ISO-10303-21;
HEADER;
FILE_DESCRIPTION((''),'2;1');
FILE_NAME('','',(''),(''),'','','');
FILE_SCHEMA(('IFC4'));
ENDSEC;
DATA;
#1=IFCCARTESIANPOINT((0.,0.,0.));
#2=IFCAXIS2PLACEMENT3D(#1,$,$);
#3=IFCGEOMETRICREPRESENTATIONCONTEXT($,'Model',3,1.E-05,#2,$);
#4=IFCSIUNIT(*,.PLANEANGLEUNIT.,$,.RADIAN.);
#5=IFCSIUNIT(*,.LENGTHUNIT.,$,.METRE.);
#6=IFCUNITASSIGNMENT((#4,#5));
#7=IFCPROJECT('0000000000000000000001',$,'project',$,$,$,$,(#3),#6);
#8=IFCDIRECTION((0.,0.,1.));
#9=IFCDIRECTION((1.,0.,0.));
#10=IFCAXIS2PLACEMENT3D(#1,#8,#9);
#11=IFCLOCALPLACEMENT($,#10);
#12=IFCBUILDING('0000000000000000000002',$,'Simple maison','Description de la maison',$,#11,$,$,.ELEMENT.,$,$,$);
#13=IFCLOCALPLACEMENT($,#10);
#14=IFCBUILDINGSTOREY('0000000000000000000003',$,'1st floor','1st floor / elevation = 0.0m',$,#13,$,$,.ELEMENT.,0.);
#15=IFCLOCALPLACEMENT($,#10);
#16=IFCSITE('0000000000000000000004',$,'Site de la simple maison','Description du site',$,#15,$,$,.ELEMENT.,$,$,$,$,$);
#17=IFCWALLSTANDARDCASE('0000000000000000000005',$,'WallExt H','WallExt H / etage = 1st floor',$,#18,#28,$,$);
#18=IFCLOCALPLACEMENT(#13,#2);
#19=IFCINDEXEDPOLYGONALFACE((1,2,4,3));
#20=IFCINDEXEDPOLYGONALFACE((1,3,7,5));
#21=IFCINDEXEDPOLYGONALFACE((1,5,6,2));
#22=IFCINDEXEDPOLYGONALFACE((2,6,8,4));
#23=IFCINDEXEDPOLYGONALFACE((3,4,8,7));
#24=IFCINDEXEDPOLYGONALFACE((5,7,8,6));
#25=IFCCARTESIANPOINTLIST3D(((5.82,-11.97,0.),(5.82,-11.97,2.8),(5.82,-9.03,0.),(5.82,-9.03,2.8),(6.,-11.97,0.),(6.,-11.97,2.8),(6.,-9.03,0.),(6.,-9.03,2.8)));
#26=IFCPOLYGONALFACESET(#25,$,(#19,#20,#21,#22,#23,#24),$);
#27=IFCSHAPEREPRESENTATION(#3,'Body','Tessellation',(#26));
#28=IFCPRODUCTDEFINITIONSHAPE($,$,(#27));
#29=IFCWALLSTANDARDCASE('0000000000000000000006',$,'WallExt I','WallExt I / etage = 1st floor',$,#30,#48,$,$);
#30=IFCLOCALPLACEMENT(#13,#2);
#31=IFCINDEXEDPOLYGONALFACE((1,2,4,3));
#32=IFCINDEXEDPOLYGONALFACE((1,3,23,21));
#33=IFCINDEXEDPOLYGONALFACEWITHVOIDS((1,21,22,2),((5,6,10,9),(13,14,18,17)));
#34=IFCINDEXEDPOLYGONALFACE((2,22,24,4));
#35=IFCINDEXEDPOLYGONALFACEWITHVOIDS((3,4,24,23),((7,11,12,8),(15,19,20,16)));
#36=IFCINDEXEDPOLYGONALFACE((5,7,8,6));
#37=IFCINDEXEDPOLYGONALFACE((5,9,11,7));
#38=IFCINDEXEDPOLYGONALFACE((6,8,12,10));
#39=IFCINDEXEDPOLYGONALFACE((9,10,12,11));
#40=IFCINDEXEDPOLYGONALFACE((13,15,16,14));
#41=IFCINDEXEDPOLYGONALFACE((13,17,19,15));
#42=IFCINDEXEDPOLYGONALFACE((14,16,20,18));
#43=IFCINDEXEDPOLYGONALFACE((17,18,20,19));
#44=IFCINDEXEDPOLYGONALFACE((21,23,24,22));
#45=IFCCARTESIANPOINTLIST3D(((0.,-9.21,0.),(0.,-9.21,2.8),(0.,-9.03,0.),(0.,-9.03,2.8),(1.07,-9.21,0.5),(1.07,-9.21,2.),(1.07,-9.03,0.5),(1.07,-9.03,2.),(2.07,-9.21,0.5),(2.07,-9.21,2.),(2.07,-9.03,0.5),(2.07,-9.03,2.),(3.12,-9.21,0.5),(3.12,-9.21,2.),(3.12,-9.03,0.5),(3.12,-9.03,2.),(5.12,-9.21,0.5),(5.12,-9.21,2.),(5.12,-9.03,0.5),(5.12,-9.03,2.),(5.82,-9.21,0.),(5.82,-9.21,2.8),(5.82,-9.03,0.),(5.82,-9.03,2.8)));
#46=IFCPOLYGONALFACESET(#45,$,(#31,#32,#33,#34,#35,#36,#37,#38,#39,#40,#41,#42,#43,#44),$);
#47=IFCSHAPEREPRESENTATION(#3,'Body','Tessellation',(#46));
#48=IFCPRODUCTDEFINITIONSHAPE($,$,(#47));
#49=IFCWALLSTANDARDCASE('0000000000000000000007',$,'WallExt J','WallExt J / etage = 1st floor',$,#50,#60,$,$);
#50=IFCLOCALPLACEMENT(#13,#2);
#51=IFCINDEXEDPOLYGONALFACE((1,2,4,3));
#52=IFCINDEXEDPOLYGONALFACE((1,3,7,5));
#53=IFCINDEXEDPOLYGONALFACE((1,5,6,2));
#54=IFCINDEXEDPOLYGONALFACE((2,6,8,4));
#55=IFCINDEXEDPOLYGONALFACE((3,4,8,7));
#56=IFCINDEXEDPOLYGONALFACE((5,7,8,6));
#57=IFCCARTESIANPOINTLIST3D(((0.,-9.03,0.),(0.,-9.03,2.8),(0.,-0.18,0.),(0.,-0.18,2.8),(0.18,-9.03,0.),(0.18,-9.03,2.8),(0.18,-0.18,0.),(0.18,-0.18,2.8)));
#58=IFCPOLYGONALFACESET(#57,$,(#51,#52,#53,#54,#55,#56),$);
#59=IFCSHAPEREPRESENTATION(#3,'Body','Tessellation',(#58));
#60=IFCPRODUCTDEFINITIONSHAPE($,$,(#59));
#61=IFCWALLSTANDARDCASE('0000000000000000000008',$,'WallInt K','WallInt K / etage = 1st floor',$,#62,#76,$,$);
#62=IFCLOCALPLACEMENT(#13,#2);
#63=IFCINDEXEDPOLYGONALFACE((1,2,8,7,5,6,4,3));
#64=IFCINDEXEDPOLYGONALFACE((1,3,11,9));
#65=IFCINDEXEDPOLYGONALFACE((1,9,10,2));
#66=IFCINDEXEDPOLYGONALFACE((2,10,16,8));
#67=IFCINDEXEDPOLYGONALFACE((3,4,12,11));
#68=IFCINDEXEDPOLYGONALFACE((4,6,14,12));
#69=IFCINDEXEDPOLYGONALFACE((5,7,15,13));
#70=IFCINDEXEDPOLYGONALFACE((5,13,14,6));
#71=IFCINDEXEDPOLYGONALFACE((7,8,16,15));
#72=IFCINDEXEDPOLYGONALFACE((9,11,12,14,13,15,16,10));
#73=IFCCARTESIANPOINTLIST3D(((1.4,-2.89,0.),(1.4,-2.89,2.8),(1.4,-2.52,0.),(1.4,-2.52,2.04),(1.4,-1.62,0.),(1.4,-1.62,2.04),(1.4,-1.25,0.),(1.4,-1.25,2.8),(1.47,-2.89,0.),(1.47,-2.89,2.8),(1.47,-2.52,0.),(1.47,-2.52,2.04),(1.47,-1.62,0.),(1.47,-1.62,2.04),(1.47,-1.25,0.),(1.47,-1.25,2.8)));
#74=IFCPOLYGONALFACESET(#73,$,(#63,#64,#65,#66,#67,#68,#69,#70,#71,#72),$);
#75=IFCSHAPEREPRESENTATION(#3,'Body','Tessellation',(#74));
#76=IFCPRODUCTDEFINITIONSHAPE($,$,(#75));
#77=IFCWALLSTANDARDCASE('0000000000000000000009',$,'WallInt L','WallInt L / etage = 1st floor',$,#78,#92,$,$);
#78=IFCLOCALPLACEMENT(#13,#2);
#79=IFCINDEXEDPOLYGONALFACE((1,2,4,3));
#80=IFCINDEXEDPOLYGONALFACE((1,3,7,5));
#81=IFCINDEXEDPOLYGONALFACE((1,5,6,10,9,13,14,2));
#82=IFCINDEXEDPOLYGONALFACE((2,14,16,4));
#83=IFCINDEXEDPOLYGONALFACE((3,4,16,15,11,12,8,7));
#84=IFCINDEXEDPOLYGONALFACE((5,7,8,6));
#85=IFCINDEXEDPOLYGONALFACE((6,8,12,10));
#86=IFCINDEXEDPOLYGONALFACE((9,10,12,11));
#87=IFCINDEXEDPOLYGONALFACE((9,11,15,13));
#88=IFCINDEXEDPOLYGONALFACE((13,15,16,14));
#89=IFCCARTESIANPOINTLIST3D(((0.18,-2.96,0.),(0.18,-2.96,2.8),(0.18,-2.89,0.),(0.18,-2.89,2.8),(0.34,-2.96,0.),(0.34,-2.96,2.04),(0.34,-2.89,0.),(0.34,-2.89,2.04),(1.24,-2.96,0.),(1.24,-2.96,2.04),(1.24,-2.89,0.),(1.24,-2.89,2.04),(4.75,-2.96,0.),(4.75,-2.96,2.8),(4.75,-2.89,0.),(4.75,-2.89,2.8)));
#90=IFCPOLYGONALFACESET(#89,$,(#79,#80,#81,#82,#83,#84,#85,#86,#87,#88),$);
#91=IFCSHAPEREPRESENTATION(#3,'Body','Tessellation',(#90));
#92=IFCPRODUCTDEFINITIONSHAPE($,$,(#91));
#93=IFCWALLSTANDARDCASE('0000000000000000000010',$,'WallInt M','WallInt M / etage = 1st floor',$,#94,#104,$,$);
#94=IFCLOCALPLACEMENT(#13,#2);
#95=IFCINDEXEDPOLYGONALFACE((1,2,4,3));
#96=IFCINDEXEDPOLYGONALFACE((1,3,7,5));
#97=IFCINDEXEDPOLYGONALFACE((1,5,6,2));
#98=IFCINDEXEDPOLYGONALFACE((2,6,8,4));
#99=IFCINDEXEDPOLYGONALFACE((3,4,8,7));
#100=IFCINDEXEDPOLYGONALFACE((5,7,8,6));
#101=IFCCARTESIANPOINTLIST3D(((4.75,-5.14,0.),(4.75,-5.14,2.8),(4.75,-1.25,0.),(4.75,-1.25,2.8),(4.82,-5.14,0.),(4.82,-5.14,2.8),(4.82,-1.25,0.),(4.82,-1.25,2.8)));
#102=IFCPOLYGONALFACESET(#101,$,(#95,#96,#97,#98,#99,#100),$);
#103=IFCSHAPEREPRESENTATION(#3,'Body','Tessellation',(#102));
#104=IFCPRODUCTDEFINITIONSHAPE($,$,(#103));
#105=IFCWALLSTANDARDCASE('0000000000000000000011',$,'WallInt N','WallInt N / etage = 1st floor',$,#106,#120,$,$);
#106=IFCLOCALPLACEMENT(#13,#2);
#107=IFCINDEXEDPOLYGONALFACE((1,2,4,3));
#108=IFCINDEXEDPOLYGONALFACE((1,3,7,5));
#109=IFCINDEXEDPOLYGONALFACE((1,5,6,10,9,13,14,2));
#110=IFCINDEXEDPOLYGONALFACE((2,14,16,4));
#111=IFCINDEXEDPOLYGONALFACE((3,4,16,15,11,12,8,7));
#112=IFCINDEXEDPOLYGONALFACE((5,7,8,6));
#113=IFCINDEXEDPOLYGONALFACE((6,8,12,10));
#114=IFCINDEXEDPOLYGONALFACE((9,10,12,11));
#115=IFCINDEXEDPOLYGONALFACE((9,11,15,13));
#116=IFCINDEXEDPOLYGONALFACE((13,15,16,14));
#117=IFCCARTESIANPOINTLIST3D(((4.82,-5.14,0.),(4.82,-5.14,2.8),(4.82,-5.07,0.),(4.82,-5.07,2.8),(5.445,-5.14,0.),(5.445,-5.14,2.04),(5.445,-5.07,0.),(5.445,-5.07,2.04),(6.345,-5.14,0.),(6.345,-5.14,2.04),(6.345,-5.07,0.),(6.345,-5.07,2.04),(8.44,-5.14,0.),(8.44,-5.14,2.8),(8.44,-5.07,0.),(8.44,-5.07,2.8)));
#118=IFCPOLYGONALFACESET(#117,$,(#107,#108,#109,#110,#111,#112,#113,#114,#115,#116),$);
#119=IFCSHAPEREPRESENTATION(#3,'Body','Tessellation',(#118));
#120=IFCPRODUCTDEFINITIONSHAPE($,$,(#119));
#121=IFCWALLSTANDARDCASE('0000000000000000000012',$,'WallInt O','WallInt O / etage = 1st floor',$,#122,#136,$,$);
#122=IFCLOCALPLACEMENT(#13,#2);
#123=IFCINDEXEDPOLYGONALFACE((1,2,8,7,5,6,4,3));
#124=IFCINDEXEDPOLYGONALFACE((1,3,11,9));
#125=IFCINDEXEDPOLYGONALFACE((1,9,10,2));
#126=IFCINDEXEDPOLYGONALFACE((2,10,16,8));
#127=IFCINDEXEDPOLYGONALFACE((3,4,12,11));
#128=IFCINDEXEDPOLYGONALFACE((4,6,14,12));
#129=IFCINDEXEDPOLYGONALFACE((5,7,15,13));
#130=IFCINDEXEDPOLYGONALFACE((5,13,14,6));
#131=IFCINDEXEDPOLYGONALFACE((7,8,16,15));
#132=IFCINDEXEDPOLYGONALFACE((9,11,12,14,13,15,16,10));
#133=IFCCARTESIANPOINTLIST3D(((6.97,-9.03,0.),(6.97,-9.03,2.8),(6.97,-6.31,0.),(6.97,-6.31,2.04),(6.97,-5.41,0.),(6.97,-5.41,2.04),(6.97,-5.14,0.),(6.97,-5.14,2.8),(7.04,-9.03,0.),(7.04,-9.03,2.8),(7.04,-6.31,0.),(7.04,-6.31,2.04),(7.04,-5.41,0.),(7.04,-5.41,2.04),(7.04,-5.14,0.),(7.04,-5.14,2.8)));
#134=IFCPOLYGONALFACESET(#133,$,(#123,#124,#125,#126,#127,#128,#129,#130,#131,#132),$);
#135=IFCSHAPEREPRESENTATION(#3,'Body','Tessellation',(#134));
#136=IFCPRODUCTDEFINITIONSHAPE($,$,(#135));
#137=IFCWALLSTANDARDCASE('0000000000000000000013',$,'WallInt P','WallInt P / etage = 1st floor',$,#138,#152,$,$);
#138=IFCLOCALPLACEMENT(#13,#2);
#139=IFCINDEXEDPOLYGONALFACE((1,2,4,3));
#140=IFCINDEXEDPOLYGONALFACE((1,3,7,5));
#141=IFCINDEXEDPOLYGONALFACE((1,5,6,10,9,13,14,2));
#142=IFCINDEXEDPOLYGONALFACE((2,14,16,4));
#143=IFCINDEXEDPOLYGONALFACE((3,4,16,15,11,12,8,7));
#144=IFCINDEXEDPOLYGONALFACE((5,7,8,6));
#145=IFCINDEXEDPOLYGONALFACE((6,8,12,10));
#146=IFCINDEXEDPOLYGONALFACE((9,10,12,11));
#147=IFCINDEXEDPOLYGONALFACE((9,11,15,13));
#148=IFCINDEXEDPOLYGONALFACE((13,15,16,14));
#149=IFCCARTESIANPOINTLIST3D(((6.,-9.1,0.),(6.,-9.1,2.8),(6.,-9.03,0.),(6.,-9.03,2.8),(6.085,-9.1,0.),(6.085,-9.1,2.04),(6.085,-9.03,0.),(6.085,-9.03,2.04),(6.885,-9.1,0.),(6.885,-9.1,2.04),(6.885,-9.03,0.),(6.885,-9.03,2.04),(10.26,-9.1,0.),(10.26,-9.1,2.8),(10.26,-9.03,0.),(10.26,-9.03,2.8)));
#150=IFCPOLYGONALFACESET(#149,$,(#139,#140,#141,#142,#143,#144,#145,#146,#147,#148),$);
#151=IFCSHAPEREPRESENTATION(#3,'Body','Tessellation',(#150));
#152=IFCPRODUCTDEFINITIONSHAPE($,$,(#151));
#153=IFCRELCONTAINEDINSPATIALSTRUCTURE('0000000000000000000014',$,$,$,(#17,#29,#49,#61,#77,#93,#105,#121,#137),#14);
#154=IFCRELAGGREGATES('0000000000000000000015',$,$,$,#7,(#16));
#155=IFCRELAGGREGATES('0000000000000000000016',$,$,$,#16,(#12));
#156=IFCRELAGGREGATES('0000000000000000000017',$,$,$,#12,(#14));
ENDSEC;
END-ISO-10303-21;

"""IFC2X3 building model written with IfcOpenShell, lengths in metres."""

from ifc_helpers import new_model, si_unit, frame, origin, origin_with_axes, origin_2d_with_axis, place, context, project, spatial, polyline, rectangle, outline, extrude, element, save


model = new_model("IFC2X3")

# Units and contexts
model_context = context("Model", 3, precision=1e-05, world=origin())
ifc_project = project(units=[si_unit("PLANEANGLEUNIT", "RADIAN"), si_unit("LENGTHUNIT", "METRE")], contexts=[model_context])

# Site, building, storey
site_placement = place(None, origin_with_axes())
site = spatial("IfcSite", under=ifc_project, at=site_placement, Name="Site de la simple maison", Description="Description du site", CompositionType="ELEMENT")
building_placement = place(None, origin_with_axes())
building = spatial("IfcBuilding", under=site, at=building_placement, Name="Simple maison", Description="Description de la maison", CompositionType="ELEMENT")
storey_placement = place(None, origin_with_axes())
storey = spatial("IfcBuildingStorey", under=building, at=storey_placement, Name="1st floor", Description="1st floor / elevation = 0.0m", CompositionType="ELEMENT", Elevation=0.0)

# Wall
wall_1_placement = place(storey_placement, frame((5.91, -11.97, 0.0), z_axis=(0.0, 0.0, 1.0), x_axis=(0.0, 1.0, 0.0)))
element("IfcWallStandardCase", 1, at=wall_1_placement, inside=storey, Name="WallExt H", Description="WallExt H / etage = 1st floor", context=model_context, shape_type="SweptSolid", body=[
    extrude(outline(polyline([(0.0, 0.09), (2.94, 0.09), (2.94, -0.09), (0.0, -0.09)])), origin(), (0.0, 0.0, 1.0), 2.8),
])

# Wall, openings
wall_2_placement = place(storey_placement, frame((5.82, -9.12, 0.0), z_axis=(0.0, 0.0, 1.0), x_axis=(-1.0, 0.0, 0.0)))
wall_2 = element("IfcWallStandardCase", 2, at=wall_2_placement, inside=storey, Name="WallExt I", Description="WallExt I / etage = 1st floor", context=model_context, shape_type="SweptSolid", body=[
    extrude(outline(polyline([(0.0, 0.09), (5.82, 0.09), (5.82, -0.09), (0.0, -0.09)])), origin(), (0.0, 0.0, 1.0), 2.8),
])
opening_1_placement = place(wall_2_placement, frame((3.75, -0.09, 0.5), z_axis=(0.0, 0.0, 1.0), x_axis=(1.0, 0.0, 0.0)))
element("IfcOpeningElement", 3, at=opening_1_placement, cuts=wall_2, context=model_context, shape_type="SweptSolid", body=[
    extrude(rectangle(XDim=1.5, YDim=1.0, at=origin_2d_with_axis()), frame((0.5, 0.0, 0.75), z_axis=(0.0, 1.0, 0.0), x_axis=(0.0, 0.0, 1.0)), (0.0, 0.0, 1.0), 0.18),
])
opening_2_placement = place(wall_2_placement, frame((0.7, -0.09, 0.5), z_axis=(0.0, 0.0, 1.0), x_axis=(1.0, 0.0, 0.0)))
element("IfcOpeningElement", 4, at=opening_2_placement, cuts=wall_2, context=model_context, shape_type="SweptSolid", body=[
    extrude(rectangle(XDim=1.5, YDim=2.0, at=origin_2d_with_axis()), frame((1.0, 0.0, 0.75), z_axis=(0.0, 1.0, 0.0), x_axis=(0.0, 0.0, 1.0)), (0.0, 0.0, 1.0), 0.18),
])

# Wall
wall_3_placement = place(storey_placement, frame((0.09, -9.03, 0.0), z_axis=(0.0, 0.0, 1.0), x_axis=(0.0, 1.0, 0.0)))
element("IfcWallStandardCase", 5, at=wall_3_placement, inside=storey, Name="WallExt J", Description="WallExt J / etage = 1st floor", context=model_context, shape_type="SweptSolid", body=[
    extrude(outline(polyline([(0.0, 0.09), (8.85, 0.09), (8.85, -0.09), (0.0, -0.09)])), origin(), (0.0, 0.0, 1.0), 2.8),
])

# Walls, openings
wall_4_placement = place(storey_placement, frame((1.435, -1.25, 0.0), z_axis=(0.0, 0.0, 1.0), x_axis=(0.0, -1.0, 0.0)))
wall_4 = element("IfcWallStandardCase", 6, at=wall_4_placement, inside=storey, Name="WallInt K", Description="WallInt K / etage = 1st floor", context=model_context, shape_type="SweptSolid", body=[
    extrude(outline(polyline([(0.0, 0.035), (1.64, 0.035), (1.64, -0.035), (0.0, -0.035)])), origin(), (0.0, 0.0, 1.0), 2.8),
])
opening_3_placement = place(wall_4_placement, frame((0.37, -0.035, 0.0), z_axis=(0.0, 0.0, 1.0), x_axis=(1.0, 0.0, 0.0)))
element("IfcOpeningElement", 7, at=opening_3_placement, cuts=wall_4, context=model_context, shape_type="SweptSolid", body=[
    extrude(rectangle(XDim=2.04, YDim=0.9, at=origin_2d_with_axis()), frame((0.45, 0.0, 1.02), z_axis=(0.0, 1.0, 0.0), x_axis=(0.0, 0.0, 1.0)), (0.0, 0.0, 1.0), 0.07),
])
wall_5_placement = place(storey_placement, frame((0.18, -2.925, 0.0), z_axis=(0.0, 0.0, 1.0), x_axis=(1.0, 0.0, 0.0)))
wall_5 = element("IfcWallStandardCase", 8, at=wall_5_placement, inside=storey, Name="WallInt L", Description="WallInt L / etage = 1st floor", context=model_context, shape_type="SweptSolid", body=[
    extrude(outline(polyline([(0.0, 0.035), (4.57, 0.035), (4.57, -0.035), (0.0, -0.035)])), origin(), (0.0, 0.0, 1.0), 2.8),
])
opening_4_placement = place(wall_5_placement, frame((0.16, -0.035, 0.0), z_axis=(0.0, 0.0, 1.0), x_axis=(1.0, 0.0, 0.0)))
element("IfcOpeningElement", 9, at=opening_4_placement, cuts=wall_5, context=model_context, shape_type="SweptSolid", body=[
    extrude(rectangle(XDim=2.04, YDim=0.9, at=origin_2d_with_axis()), frame((0.45, 0.0, 1.02), z_axis=(0.0, 1.0, 0.0), x_axis=(0.0, 0.0, 1.0)), (0.0, 0.0, 1.0), 0.07),
])

# Wall
wall_6_placement = place(storey_placement, frame((4.785, -1.25, 0.0), z_axis=(0.0, 0.0, 1.0), x_axis=(0.0, -1.0, 0.0)))
element("IfcWallStandardCase", 10, at=wall_6_placement, inside=storey, Name="WallInt M", Description="WallInt M / etage = 1st floor", context=model_context, shape_type="SweptSolid", body=[
    extrude(outline(polyline([(0.0, 0.035), (3.89, 0.035), (3.89, -0.035), (0.0, -0.035)])), origin(), (0.0, 0.0, 1.0), 2.8),
])

# Walls, openings
wall_7_placement = place(storey_placement, frame((4.82, -5.105, 0.0), z_axis=(0.0, 0.0, 1.0), x_axis=(1.0, 0.0, 0.0)))
wall_7 = element("IfcWallStandardCase", 11, at=wall_7_placement, inside=storey, Name="WallInt N", Description="WallInt N / etage = 1st floor", context=model_context, shape_type="SweptSolid", body=[
    extrude(outline(polyline([(0.0, 0.035), (3.62, 0.035), (3.62, -0.035), (0.0, -0.035)])), origin(), (0.0, 0.0, 1.0), 2.8),
])
opening_5_placement = place(wall_7_placement, frame((0.625, -0.035, 0.0), z_axis=(0.0, 0.0, 1.0), x_axis=(1.0, 0.0, 0.0)))
element("IfcOpeningElement", 12, at=opening_5_placement, cuts=wall_7, context=model_context, shape_type="SweptSolid", body=[
    extrude(rectangle(XDim=2.04, YDim=0.9, at=origin_2d_with_axis()), frame((0.45, 0.0, 1.02), z_axis=(0.0, 1.0, 0.0), x_axis=(0.0, 0.0, 1.0)), (0.0, 0.0, 1.0), 0.07),
])
wall_8_placement = place(storey_placement, frame((7.005, -5.14, 0.0), z_axis=(0.0, 0.0, 1.0), x_axis=(0.0, -1.0, 0.0)))
wall_8 = element("IfcWallStandardCase", 13, at=wall_8_placement, inside=storey, Name="WallInt O", Description="WallInt O / etage = 1st floor", context=model_context, shape_type="SweptSolid", body=[
    extrude(outline(polyline([(0.0, 0.035), (3.89, 0.035), (3.89, -0.035), (0.0, -0.035)])), origin(), (0.0, 0.0, 1.0), 2.8),
])
opening_6_placement = place(wall_8_placement, frame((0.27, -0.035, 0.0), z_axis=(0.0, 0.0, 1.0), x_axis=(1.0, 0.0, 0.0)))
element("IfcOpeningElement", 14, at=opening_6_placement, cuts=wall_8, context=model_context, shape_type="SweptSolid", body=[
    extrude(rectangle(XDim=2.04, YDim=0.9, at=origin_2d_with_axis()), frame((0.45, 0.0, 1.02), z_axis=(0.0, 1.0, 0.0), x_axis=(0.0, 0.0, 1.0)), (0.0, 0.0, 1.0), 0.07),
])
wall_9_placement = place(storey_placement, frame((6.0, -9.065, 0.0), z_axis=(0.0, 0.0, 1.0), x_axis=(1.0, 0.0, 0.0)))
wall_9 = element("IfcWallStandardCase", 15, at=wall_9_placement, inside=storey, Name="WallInt P", Description="WallInt P / etage = 1st floor", context=model_context, shape_type="SweptSolid", body=[
    extrude(outline(polyline([(0.0, 0.035), (4.26, 0.035), (4.26, -0.035), (0.0, -0.035)])), origin(), (0.0, 0.0, 1.0), 2.8),
])
opening_7_placement = place(wall_9_placement, frame((0.085, -0.035, 0.0), z_axis=(0.0, 0.0, 1.0), x_axis=(1.0, 0.0, 0.0)))
element("IfcOpeningElement", 16, at=opening_7_placement, cuts=wall_9, context=model_context, shape_type="SweptSolid", body=[
    extrude(rectangle(XDim=2.04, YDim=0.8, at=origin_2d_with_axis()), frame((0.4, 0.0, 1.02), z_axis=(0.0, 1.0, 0.0), x_axis=(0.0, 0.0, 1.0)), (0.0, 0.0, 1.0), 0.07),
])

save(model, "model.ifc")
